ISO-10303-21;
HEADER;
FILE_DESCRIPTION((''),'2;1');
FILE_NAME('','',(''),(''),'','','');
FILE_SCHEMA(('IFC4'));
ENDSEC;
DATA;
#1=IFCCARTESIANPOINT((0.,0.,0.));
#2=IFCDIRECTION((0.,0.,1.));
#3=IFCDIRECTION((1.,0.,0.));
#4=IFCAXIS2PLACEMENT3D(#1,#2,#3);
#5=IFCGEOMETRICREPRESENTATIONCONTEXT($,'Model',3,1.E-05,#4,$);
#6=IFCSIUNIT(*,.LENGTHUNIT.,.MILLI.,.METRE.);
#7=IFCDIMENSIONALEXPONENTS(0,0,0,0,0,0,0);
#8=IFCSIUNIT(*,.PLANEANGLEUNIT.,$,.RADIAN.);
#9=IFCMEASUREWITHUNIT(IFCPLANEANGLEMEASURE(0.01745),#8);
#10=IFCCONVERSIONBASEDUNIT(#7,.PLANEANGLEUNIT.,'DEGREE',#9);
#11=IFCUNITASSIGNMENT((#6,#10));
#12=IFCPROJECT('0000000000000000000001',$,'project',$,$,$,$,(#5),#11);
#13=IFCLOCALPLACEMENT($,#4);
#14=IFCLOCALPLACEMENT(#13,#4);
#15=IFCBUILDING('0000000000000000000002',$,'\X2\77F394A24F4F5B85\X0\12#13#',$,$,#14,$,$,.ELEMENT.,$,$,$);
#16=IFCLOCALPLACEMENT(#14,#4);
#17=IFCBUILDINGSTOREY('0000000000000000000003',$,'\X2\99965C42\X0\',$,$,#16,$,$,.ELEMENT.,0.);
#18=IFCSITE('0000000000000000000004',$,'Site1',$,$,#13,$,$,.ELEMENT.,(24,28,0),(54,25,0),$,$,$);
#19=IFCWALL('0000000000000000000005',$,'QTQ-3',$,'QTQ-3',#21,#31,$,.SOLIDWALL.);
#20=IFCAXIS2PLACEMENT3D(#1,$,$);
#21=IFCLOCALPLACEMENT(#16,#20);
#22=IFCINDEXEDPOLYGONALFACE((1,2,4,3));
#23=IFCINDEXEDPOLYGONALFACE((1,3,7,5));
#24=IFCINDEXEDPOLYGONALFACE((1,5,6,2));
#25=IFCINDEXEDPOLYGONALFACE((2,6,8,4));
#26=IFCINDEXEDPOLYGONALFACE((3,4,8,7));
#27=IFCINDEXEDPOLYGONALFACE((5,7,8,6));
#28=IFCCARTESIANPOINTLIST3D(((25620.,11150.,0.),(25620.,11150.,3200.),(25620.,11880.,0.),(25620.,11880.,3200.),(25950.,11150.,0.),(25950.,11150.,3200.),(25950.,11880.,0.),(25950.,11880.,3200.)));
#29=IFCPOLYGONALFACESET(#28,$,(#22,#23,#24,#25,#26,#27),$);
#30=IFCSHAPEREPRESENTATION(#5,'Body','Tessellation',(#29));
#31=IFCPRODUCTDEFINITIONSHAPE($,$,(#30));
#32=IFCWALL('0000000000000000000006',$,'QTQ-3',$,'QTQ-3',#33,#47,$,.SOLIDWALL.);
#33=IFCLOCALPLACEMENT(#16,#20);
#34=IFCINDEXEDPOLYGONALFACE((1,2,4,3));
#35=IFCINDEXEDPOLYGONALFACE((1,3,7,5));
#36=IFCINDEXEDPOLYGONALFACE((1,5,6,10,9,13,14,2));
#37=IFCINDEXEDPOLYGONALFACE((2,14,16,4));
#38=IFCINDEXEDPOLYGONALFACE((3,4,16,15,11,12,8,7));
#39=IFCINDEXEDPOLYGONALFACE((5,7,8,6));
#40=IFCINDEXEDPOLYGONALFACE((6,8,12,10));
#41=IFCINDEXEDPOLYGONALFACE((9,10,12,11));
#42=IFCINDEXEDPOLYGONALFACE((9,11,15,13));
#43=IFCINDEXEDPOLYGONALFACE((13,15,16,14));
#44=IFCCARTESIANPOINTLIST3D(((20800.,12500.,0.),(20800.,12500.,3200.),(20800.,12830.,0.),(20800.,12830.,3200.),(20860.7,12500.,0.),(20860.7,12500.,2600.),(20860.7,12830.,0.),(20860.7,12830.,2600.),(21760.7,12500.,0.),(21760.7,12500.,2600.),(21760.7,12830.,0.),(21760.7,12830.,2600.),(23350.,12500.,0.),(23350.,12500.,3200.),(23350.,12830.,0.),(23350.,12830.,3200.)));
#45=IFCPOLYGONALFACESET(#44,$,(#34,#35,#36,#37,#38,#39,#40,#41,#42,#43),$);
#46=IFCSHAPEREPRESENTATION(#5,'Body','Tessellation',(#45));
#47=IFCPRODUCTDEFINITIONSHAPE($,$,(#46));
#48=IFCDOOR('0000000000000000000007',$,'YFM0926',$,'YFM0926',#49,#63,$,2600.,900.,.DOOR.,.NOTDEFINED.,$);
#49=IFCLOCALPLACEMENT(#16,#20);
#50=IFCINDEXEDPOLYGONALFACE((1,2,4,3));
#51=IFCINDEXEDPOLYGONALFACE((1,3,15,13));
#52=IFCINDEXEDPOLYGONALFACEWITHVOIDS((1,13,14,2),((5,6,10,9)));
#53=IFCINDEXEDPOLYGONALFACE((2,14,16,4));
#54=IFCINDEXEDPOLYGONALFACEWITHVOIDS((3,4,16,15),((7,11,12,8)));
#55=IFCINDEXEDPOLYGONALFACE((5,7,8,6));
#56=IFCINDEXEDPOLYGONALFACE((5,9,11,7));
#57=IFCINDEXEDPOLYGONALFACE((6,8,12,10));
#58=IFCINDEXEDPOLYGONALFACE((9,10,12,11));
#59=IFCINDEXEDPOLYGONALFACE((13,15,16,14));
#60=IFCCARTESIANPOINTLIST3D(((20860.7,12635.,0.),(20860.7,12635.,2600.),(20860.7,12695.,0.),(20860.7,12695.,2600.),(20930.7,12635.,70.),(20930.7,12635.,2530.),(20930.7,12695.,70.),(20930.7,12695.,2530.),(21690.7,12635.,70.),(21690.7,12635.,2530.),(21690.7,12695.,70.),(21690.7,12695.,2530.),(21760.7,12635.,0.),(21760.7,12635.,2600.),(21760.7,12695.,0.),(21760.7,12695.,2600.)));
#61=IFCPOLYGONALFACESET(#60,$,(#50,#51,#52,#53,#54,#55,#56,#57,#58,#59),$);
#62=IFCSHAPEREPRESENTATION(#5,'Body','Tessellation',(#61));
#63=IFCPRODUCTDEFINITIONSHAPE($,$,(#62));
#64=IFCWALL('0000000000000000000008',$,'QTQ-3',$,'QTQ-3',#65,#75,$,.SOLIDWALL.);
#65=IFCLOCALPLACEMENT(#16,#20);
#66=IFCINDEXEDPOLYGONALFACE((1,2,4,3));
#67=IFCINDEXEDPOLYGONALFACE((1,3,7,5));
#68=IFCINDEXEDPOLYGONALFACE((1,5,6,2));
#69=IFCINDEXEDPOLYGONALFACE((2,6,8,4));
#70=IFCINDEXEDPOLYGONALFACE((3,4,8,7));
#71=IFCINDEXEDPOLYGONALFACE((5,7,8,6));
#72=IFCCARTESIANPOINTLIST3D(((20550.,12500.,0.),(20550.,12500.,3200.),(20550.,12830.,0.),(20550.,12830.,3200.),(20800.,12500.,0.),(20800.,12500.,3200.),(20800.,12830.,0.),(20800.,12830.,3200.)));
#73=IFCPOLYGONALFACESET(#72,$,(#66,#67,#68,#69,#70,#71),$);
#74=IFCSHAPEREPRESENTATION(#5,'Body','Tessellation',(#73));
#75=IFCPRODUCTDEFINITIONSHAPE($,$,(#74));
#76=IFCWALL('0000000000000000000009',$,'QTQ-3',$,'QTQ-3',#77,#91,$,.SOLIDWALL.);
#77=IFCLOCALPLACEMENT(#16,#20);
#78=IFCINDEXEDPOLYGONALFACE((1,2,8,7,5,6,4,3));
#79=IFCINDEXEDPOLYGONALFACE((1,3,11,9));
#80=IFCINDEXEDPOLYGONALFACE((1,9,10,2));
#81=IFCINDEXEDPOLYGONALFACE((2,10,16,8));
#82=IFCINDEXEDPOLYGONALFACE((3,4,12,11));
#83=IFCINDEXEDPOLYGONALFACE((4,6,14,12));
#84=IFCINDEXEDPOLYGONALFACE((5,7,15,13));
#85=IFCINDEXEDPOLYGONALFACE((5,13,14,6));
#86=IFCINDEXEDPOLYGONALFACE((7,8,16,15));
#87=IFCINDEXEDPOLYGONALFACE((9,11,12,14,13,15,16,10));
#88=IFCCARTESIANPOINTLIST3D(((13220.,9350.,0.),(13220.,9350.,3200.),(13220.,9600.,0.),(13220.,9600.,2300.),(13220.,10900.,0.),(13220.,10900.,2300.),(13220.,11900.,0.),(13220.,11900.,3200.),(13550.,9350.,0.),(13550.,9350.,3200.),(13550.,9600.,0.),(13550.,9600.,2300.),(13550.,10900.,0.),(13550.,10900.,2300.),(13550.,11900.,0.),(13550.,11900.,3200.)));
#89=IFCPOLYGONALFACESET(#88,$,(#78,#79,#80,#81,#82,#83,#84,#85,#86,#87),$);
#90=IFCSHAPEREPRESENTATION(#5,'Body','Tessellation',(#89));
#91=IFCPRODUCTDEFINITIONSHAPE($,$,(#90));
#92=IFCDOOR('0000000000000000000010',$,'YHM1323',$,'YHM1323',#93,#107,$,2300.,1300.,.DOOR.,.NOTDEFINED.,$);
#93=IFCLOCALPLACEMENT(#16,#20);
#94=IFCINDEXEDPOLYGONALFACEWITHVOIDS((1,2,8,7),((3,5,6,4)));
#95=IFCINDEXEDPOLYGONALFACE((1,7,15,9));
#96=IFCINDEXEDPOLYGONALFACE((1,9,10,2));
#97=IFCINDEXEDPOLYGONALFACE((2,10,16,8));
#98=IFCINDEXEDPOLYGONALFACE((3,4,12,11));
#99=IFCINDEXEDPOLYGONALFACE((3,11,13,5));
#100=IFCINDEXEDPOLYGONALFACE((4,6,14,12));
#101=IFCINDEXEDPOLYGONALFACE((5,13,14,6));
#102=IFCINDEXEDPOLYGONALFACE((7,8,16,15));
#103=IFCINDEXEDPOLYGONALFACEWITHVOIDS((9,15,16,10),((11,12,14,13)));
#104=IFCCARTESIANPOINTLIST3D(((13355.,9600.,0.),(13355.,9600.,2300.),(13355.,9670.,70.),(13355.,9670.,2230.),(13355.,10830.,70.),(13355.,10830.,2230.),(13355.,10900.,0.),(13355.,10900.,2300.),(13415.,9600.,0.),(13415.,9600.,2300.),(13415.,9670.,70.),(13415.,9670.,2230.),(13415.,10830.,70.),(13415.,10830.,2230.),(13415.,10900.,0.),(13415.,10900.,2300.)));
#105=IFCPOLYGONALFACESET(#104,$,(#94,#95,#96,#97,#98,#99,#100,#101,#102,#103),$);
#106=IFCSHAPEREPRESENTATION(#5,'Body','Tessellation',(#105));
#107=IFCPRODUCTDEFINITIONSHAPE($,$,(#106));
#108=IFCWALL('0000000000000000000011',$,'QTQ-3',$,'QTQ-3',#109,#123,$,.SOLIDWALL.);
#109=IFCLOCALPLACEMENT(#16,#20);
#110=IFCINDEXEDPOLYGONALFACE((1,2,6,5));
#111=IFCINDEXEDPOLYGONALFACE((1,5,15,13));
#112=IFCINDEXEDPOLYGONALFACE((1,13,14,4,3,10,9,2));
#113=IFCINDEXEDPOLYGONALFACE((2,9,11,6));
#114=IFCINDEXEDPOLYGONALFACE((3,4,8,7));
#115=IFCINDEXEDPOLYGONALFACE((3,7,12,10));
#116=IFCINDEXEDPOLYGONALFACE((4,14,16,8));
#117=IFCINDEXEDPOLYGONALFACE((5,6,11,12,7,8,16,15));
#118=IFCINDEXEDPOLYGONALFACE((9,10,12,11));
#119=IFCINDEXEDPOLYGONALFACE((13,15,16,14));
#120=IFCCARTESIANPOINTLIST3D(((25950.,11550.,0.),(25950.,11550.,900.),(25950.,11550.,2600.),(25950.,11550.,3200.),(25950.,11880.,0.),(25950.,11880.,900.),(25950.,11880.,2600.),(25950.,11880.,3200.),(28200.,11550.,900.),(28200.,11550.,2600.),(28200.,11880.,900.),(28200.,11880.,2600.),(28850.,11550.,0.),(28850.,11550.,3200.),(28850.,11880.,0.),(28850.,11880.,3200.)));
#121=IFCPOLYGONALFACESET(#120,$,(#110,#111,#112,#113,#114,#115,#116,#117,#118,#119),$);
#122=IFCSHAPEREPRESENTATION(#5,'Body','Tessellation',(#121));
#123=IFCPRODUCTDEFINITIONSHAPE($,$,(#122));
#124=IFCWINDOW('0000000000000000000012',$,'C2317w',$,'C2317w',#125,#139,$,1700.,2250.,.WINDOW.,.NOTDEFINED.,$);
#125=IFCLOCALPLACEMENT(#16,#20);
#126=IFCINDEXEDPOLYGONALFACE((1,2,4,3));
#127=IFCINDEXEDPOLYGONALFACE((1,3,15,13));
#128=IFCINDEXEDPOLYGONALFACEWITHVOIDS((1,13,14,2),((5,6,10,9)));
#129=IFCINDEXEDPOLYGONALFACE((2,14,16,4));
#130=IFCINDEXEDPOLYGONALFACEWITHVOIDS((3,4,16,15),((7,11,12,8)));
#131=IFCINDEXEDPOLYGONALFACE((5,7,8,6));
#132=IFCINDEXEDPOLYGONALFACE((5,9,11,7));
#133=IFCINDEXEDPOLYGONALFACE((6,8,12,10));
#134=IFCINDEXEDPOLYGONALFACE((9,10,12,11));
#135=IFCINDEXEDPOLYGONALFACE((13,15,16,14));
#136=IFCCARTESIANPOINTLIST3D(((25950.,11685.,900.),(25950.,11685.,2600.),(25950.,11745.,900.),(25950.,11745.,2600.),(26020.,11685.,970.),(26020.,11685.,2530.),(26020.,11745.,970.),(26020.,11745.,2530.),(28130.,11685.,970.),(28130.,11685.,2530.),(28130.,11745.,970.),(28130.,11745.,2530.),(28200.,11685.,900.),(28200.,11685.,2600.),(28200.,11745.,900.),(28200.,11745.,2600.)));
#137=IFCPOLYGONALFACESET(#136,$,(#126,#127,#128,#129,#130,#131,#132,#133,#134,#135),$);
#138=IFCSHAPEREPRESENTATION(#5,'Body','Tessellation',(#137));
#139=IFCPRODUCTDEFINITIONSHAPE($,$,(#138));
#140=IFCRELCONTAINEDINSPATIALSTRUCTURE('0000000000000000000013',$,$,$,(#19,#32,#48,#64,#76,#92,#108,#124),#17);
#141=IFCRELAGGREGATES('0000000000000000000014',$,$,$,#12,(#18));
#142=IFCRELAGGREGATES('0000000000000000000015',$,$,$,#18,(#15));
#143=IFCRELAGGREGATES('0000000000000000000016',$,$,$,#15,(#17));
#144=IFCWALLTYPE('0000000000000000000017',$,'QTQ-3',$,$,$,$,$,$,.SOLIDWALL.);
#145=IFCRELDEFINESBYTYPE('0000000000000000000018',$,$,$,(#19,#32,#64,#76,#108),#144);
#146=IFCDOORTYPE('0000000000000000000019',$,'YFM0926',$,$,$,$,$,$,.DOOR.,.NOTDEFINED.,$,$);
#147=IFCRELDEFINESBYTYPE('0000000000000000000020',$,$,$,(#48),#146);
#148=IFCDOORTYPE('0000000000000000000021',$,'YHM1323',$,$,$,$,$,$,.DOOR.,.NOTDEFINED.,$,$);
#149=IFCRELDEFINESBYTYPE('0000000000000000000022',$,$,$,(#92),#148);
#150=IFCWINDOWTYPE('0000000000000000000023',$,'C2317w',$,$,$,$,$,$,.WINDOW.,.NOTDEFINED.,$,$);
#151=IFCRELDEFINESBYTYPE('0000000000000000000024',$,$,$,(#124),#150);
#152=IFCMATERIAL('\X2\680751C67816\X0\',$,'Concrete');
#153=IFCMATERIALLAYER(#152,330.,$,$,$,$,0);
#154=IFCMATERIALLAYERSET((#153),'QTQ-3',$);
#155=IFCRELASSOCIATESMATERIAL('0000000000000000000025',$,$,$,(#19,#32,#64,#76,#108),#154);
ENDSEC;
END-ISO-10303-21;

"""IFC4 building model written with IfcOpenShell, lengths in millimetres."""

from ifc_helpers import new_model, entity, si_unit, converted_unit, frame, origin_with_axes, place, context, project, spatial, polyline, outline, extrude, material, layer, layer_set, type_object, element, fill, save


model = new_model("IFC4")

# Units and contexts
model_context = context("Model", 3, precision=1e-05, world=origin_with_axes())
ifc_project = project(units=[si_unit("LENGTHUNIT", "METRE", prefix="MILLI"), converted_unit("PLANEANGLEUNIT", "DEGREE", entity("IfcPlaneAngleMeasure", 0.01745), si_unit("PLANEANGLEUNIT", "RADIAN"), dimensions=[0, 0, 0, 0, 0, 0, 0])], contexts=[model_context])

# Site, building, storey
site_placement = place(None, origin_with_axes())
site = spatial("IfcSite", under=ifc_project, at=site_placement, Name="Site1", CompositionType="ELEMENT", RefLatitude=(24, 28, 0), RefLongitude=(54, 25, 0))
building_placement = place(site_placement, origin_with_axes())
building = spatial("IfcBuilding", under=site, at=building_placement, Name="石钢住宅12#13#", CompositionType="ELEMENT")
storey_placement = place(building_placement, origin_with_axes())
storey = spatial("IfcBuildingStorey", under=building, at=storey_placement, Name="首层", CompositionType="ELEMENT", Elevation=0.0)

# Shared definitions
ifc_material = material(Name="标准砖", Category="Concrete")
ifc_layer = layer(ifc_material, 330.0, Priority=0)
ifc_layer_set = layer_set([ifc_layer], Name="QTQ-3")
wall_type = type_object("IfcWallType", Name="QTQ-3", PredefinedType="SOLIDWALL")

# Wall
wall_1_placement = place(storey_placement, origin_with_axes())
element("IfcWall", 1, at=wall_1_placement, inside=storey, type_object=wall_type, material=ifc_layer_set, Name="QTQ-3", ObjectType="QTQ-3", PredefinedType="SOLIDWALL", context=model_context, shape_type="SweptSolid", body=[
    extrude(outline(polyline([(0.0, 0.0), (3200.0, 0.0), (3200.0, 730.0), (0.0, 730.0), (0.0, 0.0)])), frame((25950.0, 11880.0, 3200.0), z_axis=(-1.0, 0.0, 0.0), x_axis=(0.0, 0.0, -1.0)), (0.0, 0.0, 1.0), 330.0),
])

# Wall, opening, door
wall_2_placement = place(storey_placement, origin_with_axes())
wall_2 = element("IfcWall", 2, at=wall_2_placement, inside=storey, type_object=wall_type, material=ifc_layer_set, Name="QTQ-3", ObjectType="QTQ-3", PredefinedType="SOLIDWALL", context=model_context, shape_type="SweptSolid", body=[
    extrude(outline(polyline([(0.0, 0.0), (3200.0, 0.0), (3200.0, 2550.0), (0.0, 2550.0), (0.0, 0.0)])), frame((20800.0, 12830.0, 3200.0), z_axis=(0.0, -1.0, 0.0), x_axis=(0.0, 0.0, -1.0)), (0.0, 0.0, 1.0), 330.0),
])
opening_1_placement = place(storey_placement, origin_with_axes())
opening_1 = element("IfcOpeningElement", 3, at=opening_1_placement, cuts=wall_2, PredefinedType="OPENING", context=model_context, shape_type="SweptSolid", body=[
    extrude(outline(polyline([(0.0, 0.0), (900.0, 0.0), (900.0, 2600.0), (0.0, 2600.0), (0.0, 0.0)])), frame((20860.7, 13830.0, 0.0), z_axis=(0.0, -1.0, 0.0), x_axis=(1.0, 0.0, 0.0)), (0.0, 0.0, 1.0), 2330.0),
])
door_type_1 = type_object("IfcDoorType", Name="YFM0926", OperationType="NOTDEFINED", PredefinedType="DOOR")
door_1_placement = place(storey_placement, origin_with_axes())
door_1 = element("IfcDoor", 4, at=door_1_placement, inside=storey, type_object=door_type_1, Name="YFM0926", ObjectType="YFM0926", OperationType="NOTDEFINED", OverallHeight=2600.0, OverallWidth=900.0, PredefinedType="DOOR", context=model_context, shape_type="SweptSolid", body=[
    extrude(outline(polyline([(-450.0, -1300.0), (450.0, -1300.0), (450.0, 1300.0), (-450.0, 1300.0), (-450.0, -1300.0)]), holes=[polyline([(-380.0, -1230.0), (-380.0, 1230.0), (380.0, 1230.0), (380.0, -1230.0), (-380.0, -1230.0)])]), frame((21310.7, 12695.0, 1300.0), z_axis=(0.0, -1.0, 0.0), x_axis=(1.0, 0.0, 0.0)), (0.0, 0.0, 1.0), 60.0),
])
fill(opening_1, door_1)

# Wall
wall_3_placement = place(storey_placement, origin_with_axes())
element("IfcWall", 5, at=wall_3_placement, inside=storey, type_object=wall_type, material=ifc_layer_set, Name="QTQ-3", ObjectType="QTQ-3", PredefinedType="SOLIDWALL", context=model_context, shape_type="SweptSolid", body=[
    extrude(outline(polyline([(0.0, 0.0), (3200.0, 0.0), (3200.0, 250.0), (0.0, 250.0), (0.0, 0.0)])), frame((20550.0, 12830.0, 3200.0), z_axis=(0.0, -1.0, 0.0), x_axis=(0.0, 0.0, -1.0)), (0.0, 0.0, 1.0), 330.0),
])

# Wall, opening, door
wall_4_placement = place(storey_placement, origin_with_axes())
wall_4 = element("IfcWall", 6, at=wall_4_placement, inside=storey, type_object=wall_type, material=ifc_layer_set, Name="QTQ-3", ObjectType="QTQ-3", PredefinedType="SOLIDWALL", context=model_context, shape_type="SweptSolid", body=[
    extrude(outline(polyline([(0.0, 0.0), (3200.0, 0.0), (3200.0, 2550.0), (0.0, 2550.0), (0.0, 0.0)])), frame((13220.0, 9350.0, 3200.0), z_axis=(1.0, 0.0, 0.0), x_axis=(0.0, 0.0, -1.0)), (0.0, 0.0, 1.0), 330.0),
])
opening_2_placement = place(storey_placement, origin_with_axes())
opening_2 = element("IfcOpeningElement", 7, at=opening_2_placement, cuts=wall_4, PredefinedType="OPENING", context=model_context, shape_type="SweptSolid", body=[
    extrude(outline(polyline([(0.0, 0.0), (1300.0, 0.0), (1300.0, 2300.0), (0.0, 2300.0), (0.0, 0.0)])), frame((12220.0, 9600.0, 0.0), z_axis=(1.0, 0.0, 0.0), x_axis=(0.0, 1.0, 0.0)), (0.0, 0.0, 1.0), 2330.0),
])
door_type_2 = type_object("IfcDoorType", Name="YHM1323", OperationType="NOTDEFINED", PredefinedType="DOOR")
door_2_placement = place(storey_placement, origin_with_axes())
door_2 = element("IfcDoor", 8, at=door_2_placement, inside=storey, type_object=door_type_2, Name="YHM1323", ObjectType="YHM1323", OperationType="NOTDEFINED", OverallHeight=2300.0, OverallWidth=1300.0, PredefinedType="DOOR", context=model_context, shape_type="SweptSolid", body=[
    extrude(outline(polyline([(-650.0, -1150.0), (650.0, -1150.0), (650.0, 1150.0), (-650.0, 1150.0), (-650.0, -1150.0)]), holes=[polyline([(-580.0, -1080.0), (-580.0, 1080.0), (580.0, 1080.0), (580.0, -1080.0), (-580.0, -1080.0)])]), frame((13355.0, 10250.0, 1150.0), z_axis=(1.0, 0.0, 0.0), x_axis=(0.0, 1.0, 0.0)), (0.0, 0.0, 1.0), 60.0),
])
fill(opening_2, door_2)

# Wall, opening, window
wall_5_placement = place(storey_placement, origin_with_axes())
wall_5 = element("IfcWall", 9, at=wall_5_placement, inside=storey, type_object=wall_type, material=ifc_layer_set, Name="QTQ-3", ObjectType="QTQ-3", PredefinedType="SOLIDWALL", context=model_context, shape_type="SweptSolid", body=[
    extrude(outline(polyline([(0.0, 0.0), (3200.0, 0.0), (3200.0, 2900.0), (0.0, 2900.0), (0.0, 0.0)])), frame((25950.0, 11880.0, 3200.0), z_axis=(0.0, -1.0, 0.0), x_axis=(0.0, 0.0, -1.0)), (0.0, 0.0, 1.0), 330.0),
])
opening_3_placement = place(storey_placement, origin_with_axes())
opening_3 = element("IfcOpeningElement", 10, at=opening_3_placement, cuts=wall_5, PredefinedType="OPENING", context=model_context, shape_type="SweptSolid", body=[
    extrude(outline(polyline([(0.0, 0.0), (2250.0, 0.0), (2250.0, 1700.0), (0.0, 1700.0), (0.0, 0.0)])), frame((25950.0, 12880.0, 900.0), z_axis=(0.0, -1.0, 0.0), x_axis=(1.0, 0.0, 0.0)), (0.0, 0.0, 1.0), 2330.0),
])
window_type_1 = type_object("IfcWindowType", Name="C2317w", PartitioningType="NOTDEFINED", PredefinedType="WINDOW")
window_1_placement = place(storey_placement, origin_with_axes())
window_1 = element("IfcWindow", 11, at=window_1_placement, inside=storey, type_object=window_type_1, Name="C2317w", ObjectType="C2317w", OverallHeight=1700.0, OverallWidth=2250.0, PartitioningType="NOTDEFINED", PredefinedType="WINDOW", context=model_context, shape_type="SweptSolid", body=[
    extrude(outline(polyline([(-1125.0, -850.0), (1125.0, -850.0), (1125.0, 850.0), (-1125.0, 850.0), (-1125.0, -850.0)]), holes=[polyline([(-1055.0, -780.0), (-1055.0, 780.0), (1055.0, 780.0), (1055.0, -780.0), (-1055.0, -780.0)])]), frame((27075.0, 11745.0, 1750.0), z_axis=(0.0, -1.0, 0.0), x_axis=(1.0, 0.0, 0.0)), (0.0, 0.0, 1.0), 60.0),
])
fill(opening_3, window_1)

save(model, "model.ifc")
